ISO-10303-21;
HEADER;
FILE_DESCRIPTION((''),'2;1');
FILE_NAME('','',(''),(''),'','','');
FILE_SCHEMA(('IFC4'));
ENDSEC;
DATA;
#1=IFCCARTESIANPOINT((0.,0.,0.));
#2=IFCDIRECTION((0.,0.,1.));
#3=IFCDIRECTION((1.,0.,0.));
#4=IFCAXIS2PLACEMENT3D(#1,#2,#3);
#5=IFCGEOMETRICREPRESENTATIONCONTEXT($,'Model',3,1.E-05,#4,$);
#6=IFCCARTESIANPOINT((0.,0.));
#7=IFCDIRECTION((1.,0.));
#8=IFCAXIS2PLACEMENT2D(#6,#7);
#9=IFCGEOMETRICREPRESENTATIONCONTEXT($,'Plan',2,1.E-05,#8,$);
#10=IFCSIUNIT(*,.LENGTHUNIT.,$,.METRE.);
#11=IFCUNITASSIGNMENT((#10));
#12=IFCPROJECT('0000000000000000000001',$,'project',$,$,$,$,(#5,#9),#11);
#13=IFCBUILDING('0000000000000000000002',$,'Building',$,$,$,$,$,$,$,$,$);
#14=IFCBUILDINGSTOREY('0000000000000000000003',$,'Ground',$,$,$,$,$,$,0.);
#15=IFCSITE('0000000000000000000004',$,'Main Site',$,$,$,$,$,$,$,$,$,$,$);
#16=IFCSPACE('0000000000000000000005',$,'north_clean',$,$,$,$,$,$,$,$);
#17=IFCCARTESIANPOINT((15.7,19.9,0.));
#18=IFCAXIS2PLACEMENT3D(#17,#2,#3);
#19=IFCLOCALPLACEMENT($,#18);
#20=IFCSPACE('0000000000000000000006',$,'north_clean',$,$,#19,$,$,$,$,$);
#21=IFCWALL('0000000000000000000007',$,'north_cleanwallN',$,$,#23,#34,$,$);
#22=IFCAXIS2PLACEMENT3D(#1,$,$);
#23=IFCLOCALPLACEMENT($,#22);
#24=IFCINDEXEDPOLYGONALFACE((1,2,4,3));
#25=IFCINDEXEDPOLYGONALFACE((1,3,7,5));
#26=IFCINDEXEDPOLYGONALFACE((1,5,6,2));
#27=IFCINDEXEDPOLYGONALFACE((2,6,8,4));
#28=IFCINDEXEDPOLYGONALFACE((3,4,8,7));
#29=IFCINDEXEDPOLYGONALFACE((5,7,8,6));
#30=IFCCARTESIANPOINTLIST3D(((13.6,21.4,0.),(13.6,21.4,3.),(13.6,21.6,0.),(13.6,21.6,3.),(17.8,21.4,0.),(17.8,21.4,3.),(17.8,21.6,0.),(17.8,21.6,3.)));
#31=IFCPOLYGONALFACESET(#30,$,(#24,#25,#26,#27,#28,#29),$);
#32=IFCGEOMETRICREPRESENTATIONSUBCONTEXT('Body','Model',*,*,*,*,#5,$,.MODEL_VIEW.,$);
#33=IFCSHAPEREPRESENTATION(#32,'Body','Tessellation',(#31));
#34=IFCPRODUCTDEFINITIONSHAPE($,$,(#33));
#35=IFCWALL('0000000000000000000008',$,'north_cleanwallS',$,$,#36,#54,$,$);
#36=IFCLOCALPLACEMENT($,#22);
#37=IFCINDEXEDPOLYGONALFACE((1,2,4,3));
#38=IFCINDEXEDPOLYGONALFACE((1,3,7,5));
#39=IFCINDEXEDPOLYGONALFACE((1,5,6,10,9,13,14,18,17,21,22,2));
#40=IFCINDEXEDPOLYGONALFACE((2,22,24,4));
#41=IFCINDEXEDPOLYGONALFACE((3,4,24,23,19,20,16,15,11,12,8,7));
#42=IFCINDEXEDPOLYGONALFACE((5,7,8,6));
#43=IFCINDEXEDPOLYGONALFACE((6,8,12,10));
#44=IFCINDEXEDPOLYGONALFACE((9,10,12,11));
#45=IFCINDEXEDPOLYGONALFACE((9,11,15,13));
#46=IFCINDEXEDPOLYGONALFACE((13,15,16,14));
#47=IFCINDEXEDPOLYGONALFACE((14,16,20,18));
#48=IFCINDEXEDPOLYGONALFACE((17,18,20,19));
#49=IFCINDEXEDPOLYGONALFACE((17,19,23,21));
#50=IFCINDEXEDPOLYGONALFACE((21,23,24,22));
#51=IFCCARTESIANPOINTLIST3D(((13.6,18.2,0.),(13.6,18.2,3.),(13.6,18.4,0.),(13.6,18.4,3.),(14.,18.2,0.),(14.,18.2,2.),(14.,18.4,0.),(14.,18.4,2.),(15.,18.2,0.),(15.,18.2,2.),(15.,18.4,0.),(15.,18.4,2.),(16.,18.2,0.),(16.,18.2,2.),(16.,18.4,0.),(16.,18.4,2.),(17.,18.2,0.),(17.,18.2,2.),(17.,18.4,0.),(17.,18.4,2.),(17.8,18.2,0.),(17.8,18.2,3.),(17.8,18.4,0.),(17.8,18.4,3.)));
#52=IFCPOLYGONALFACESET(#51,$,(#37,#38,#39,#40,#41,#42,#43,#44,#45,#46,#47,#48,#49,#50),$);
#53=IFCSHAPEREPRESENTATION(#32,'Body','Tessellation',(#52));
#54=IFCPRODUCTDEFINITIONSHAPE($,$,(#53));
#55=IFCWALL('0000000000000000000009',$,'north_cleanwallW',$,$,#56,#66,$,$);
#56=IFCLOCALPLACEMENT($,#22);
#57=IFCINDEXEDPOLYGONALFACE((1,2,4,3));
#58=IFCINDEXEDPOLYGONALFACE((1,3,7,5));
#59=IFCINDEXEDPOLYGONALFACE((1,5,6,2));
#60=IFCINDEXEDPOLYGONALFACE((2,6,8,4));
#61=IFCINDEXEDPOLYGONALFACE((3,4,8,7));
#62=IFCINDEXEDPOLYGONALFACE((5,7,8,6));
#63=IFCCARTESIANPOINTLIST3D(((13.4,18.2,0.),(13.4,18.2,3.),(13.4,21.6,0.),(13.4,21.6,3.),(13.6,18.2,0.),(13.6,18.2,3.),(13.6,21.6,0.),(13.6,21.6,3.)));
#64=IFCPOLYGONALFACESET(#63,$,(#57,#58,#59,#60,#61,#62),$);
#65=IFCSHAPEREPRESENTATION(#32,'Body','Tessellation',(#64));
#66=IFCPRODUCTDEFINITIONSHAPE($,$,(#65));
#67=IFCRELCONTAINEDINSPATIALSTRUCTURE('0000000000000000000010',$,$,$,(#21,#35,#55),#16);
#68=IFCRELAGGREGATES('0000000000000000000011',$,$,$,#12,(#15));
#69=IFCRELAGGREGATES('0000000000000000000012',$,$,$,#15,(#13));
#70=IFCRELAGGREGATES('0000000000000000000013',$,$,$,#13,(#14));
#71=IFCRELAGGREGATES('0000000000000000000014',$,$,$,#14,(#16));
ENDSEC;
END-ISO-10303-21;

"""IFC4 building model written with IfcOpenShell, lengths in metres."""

from ifc_helpers import new_model, si_unit, frame, origin_with_axes, origin_2d_with_axis, place, context, subcontext, project, spatial, indexed_curve, outline, extrude, element, save


model = new_model("IFC4")

# Units and contexts
model_context = context("Model", 3, precision=1e-05, world=origin_with_axes())
plan_context = context("Plan", 2, precision=1e-05, world=origin_2d_with_axis())
body_context = subcontext(model_context, "Body", "Model", "MODEL_VIEW")
ifc_project = project(units=[si_unit("LENGTHUNIT", "METRE")], contexts=[model_context, plan_context])

# Site, building, storey
site = spatial("IfcSite", under=ifc_project, Name="Main Site")
building = spatial("IfcBuilding", under=site, Name="Building")
storey = spatial("IfcBuildingStorey", under=building, Name="Ground", Elevation=0.0)

# Shared definitions
space_1 = spatial("IfcSpace", under=storey, Name="north_clean")

# Walls
wall_1_placement = place(None, frame((13.6, 21.4, 0.0), z_axis=(0.0, 0.0, 1.0), x_axis=(1.0, 0.0, 0.0)))
element("IfcWall", 1, at=wall_1_placement, inside=space_1, Name="north_cleanwallN", context=body_context, shape_type="SweptSolid", body=[
    extrude(outline(indexed_curve([(0.0, 0.0), (0.0, 0.2), (4.2, 0.2), (4.2, 0.0), (0.0, 0.0)], self_intersect=False)), origin_with_axes(), (0.0, 0.0, 1.0), 3.0),
])
wall_2_placement = place(None, frame((13.6, 18.2, 0.0), z_axis=(0.0, 0.0, 1.0), x_axis=(1.0, 0.0, 0.0)))
wall_2 = element("IfcWall", 2, at=wall_2_placement, inside=space_1, Name="north_cleanwallS", context=body_context, shape_type="SweptSolid", body=[
    extrude(outline(indexed_curve([(0.0, 0.0), (0.0, 0.2), (4.2, 0.2), (4.2, 0.0), (0.0, 0.0)], self_intersect=False)), origin_with_axes(), (0.0, 0.0, 1.0), 3.0),
])

# Shared definitions
space_2_placement = place(None, frame((15.7, 19.9, 0.0), z_axis=(0.0, 0.0, 1.0), x_axis=(1.0, 0.0, 0.0)))
space_2 = spatial("IfcSpace", at=space_2_placement, Name="north_clean")

# Openings
opening_1_placement = place(wall_2_placement, frame((0.4, 0.0, 0.0), z_axis=(0.0, 0.0, 1.0), x_axis=(1.0, 0.0, 0.0)))
element("IfcOpeningElement", 3, at=opening_1_placement, inside=space_2, cuts=wall_2, context=body_context, shape_type="SweptSolid", body=[
    extrude(outline(indexed_curve([(0.0, 0.0), (0.0, 0.4), (1.0, 0.4), (1.0, 0.0), (0.0, 0.0)], self_intersect=False)), origin_with_axes(), (0.0, 0.0, 1.0), 2.0),
])
opening_2_placement = place(wall_2_placement, frame((2.4, 0.0, 0.0), z_axis=(0.0, 0.0, 1.0), x_axis=(1.0, 0.0, 0.0)))
element("IfcOpeningElement", 4, at=opening_2_placement, inside=space_2, cuts=wall_2, context=body_context, shape_type="SweptSolid", body=[
    extrude(outline(indexed_curve([(0.0, 0.0), (0.0, 0.4), (1.0, 0.4), (1.0, 0.0), (0.0, 0.0)], self_intersect=False)), origin_with_axes(), (0.0, 0.0, 1.0), 2.0),
])

# Wall
wall_3_placement = place(None, frame((13.6, 18.2, 0.0), z_axis=(0.0, 0.0, 1.0), x_axis=(0.0, 1.0, 0.0)))
element("IfcWall", 5, at=wall_3_placement, inside=space_1, Name="north_cleanwallW", context=body_context, shape_type="SweptSolid", body=[
    extrude(outline(indexed_curve([(0.0, 0.0), (0.0, 0.2), (3.4, 0.2), (3.4, 0.0), (0.0, 0.0)], self_intersect=False)), origin_with_axes(), (0.0, 0.0, 1.0), 3.0),
])

save(model, "model.ifc")
